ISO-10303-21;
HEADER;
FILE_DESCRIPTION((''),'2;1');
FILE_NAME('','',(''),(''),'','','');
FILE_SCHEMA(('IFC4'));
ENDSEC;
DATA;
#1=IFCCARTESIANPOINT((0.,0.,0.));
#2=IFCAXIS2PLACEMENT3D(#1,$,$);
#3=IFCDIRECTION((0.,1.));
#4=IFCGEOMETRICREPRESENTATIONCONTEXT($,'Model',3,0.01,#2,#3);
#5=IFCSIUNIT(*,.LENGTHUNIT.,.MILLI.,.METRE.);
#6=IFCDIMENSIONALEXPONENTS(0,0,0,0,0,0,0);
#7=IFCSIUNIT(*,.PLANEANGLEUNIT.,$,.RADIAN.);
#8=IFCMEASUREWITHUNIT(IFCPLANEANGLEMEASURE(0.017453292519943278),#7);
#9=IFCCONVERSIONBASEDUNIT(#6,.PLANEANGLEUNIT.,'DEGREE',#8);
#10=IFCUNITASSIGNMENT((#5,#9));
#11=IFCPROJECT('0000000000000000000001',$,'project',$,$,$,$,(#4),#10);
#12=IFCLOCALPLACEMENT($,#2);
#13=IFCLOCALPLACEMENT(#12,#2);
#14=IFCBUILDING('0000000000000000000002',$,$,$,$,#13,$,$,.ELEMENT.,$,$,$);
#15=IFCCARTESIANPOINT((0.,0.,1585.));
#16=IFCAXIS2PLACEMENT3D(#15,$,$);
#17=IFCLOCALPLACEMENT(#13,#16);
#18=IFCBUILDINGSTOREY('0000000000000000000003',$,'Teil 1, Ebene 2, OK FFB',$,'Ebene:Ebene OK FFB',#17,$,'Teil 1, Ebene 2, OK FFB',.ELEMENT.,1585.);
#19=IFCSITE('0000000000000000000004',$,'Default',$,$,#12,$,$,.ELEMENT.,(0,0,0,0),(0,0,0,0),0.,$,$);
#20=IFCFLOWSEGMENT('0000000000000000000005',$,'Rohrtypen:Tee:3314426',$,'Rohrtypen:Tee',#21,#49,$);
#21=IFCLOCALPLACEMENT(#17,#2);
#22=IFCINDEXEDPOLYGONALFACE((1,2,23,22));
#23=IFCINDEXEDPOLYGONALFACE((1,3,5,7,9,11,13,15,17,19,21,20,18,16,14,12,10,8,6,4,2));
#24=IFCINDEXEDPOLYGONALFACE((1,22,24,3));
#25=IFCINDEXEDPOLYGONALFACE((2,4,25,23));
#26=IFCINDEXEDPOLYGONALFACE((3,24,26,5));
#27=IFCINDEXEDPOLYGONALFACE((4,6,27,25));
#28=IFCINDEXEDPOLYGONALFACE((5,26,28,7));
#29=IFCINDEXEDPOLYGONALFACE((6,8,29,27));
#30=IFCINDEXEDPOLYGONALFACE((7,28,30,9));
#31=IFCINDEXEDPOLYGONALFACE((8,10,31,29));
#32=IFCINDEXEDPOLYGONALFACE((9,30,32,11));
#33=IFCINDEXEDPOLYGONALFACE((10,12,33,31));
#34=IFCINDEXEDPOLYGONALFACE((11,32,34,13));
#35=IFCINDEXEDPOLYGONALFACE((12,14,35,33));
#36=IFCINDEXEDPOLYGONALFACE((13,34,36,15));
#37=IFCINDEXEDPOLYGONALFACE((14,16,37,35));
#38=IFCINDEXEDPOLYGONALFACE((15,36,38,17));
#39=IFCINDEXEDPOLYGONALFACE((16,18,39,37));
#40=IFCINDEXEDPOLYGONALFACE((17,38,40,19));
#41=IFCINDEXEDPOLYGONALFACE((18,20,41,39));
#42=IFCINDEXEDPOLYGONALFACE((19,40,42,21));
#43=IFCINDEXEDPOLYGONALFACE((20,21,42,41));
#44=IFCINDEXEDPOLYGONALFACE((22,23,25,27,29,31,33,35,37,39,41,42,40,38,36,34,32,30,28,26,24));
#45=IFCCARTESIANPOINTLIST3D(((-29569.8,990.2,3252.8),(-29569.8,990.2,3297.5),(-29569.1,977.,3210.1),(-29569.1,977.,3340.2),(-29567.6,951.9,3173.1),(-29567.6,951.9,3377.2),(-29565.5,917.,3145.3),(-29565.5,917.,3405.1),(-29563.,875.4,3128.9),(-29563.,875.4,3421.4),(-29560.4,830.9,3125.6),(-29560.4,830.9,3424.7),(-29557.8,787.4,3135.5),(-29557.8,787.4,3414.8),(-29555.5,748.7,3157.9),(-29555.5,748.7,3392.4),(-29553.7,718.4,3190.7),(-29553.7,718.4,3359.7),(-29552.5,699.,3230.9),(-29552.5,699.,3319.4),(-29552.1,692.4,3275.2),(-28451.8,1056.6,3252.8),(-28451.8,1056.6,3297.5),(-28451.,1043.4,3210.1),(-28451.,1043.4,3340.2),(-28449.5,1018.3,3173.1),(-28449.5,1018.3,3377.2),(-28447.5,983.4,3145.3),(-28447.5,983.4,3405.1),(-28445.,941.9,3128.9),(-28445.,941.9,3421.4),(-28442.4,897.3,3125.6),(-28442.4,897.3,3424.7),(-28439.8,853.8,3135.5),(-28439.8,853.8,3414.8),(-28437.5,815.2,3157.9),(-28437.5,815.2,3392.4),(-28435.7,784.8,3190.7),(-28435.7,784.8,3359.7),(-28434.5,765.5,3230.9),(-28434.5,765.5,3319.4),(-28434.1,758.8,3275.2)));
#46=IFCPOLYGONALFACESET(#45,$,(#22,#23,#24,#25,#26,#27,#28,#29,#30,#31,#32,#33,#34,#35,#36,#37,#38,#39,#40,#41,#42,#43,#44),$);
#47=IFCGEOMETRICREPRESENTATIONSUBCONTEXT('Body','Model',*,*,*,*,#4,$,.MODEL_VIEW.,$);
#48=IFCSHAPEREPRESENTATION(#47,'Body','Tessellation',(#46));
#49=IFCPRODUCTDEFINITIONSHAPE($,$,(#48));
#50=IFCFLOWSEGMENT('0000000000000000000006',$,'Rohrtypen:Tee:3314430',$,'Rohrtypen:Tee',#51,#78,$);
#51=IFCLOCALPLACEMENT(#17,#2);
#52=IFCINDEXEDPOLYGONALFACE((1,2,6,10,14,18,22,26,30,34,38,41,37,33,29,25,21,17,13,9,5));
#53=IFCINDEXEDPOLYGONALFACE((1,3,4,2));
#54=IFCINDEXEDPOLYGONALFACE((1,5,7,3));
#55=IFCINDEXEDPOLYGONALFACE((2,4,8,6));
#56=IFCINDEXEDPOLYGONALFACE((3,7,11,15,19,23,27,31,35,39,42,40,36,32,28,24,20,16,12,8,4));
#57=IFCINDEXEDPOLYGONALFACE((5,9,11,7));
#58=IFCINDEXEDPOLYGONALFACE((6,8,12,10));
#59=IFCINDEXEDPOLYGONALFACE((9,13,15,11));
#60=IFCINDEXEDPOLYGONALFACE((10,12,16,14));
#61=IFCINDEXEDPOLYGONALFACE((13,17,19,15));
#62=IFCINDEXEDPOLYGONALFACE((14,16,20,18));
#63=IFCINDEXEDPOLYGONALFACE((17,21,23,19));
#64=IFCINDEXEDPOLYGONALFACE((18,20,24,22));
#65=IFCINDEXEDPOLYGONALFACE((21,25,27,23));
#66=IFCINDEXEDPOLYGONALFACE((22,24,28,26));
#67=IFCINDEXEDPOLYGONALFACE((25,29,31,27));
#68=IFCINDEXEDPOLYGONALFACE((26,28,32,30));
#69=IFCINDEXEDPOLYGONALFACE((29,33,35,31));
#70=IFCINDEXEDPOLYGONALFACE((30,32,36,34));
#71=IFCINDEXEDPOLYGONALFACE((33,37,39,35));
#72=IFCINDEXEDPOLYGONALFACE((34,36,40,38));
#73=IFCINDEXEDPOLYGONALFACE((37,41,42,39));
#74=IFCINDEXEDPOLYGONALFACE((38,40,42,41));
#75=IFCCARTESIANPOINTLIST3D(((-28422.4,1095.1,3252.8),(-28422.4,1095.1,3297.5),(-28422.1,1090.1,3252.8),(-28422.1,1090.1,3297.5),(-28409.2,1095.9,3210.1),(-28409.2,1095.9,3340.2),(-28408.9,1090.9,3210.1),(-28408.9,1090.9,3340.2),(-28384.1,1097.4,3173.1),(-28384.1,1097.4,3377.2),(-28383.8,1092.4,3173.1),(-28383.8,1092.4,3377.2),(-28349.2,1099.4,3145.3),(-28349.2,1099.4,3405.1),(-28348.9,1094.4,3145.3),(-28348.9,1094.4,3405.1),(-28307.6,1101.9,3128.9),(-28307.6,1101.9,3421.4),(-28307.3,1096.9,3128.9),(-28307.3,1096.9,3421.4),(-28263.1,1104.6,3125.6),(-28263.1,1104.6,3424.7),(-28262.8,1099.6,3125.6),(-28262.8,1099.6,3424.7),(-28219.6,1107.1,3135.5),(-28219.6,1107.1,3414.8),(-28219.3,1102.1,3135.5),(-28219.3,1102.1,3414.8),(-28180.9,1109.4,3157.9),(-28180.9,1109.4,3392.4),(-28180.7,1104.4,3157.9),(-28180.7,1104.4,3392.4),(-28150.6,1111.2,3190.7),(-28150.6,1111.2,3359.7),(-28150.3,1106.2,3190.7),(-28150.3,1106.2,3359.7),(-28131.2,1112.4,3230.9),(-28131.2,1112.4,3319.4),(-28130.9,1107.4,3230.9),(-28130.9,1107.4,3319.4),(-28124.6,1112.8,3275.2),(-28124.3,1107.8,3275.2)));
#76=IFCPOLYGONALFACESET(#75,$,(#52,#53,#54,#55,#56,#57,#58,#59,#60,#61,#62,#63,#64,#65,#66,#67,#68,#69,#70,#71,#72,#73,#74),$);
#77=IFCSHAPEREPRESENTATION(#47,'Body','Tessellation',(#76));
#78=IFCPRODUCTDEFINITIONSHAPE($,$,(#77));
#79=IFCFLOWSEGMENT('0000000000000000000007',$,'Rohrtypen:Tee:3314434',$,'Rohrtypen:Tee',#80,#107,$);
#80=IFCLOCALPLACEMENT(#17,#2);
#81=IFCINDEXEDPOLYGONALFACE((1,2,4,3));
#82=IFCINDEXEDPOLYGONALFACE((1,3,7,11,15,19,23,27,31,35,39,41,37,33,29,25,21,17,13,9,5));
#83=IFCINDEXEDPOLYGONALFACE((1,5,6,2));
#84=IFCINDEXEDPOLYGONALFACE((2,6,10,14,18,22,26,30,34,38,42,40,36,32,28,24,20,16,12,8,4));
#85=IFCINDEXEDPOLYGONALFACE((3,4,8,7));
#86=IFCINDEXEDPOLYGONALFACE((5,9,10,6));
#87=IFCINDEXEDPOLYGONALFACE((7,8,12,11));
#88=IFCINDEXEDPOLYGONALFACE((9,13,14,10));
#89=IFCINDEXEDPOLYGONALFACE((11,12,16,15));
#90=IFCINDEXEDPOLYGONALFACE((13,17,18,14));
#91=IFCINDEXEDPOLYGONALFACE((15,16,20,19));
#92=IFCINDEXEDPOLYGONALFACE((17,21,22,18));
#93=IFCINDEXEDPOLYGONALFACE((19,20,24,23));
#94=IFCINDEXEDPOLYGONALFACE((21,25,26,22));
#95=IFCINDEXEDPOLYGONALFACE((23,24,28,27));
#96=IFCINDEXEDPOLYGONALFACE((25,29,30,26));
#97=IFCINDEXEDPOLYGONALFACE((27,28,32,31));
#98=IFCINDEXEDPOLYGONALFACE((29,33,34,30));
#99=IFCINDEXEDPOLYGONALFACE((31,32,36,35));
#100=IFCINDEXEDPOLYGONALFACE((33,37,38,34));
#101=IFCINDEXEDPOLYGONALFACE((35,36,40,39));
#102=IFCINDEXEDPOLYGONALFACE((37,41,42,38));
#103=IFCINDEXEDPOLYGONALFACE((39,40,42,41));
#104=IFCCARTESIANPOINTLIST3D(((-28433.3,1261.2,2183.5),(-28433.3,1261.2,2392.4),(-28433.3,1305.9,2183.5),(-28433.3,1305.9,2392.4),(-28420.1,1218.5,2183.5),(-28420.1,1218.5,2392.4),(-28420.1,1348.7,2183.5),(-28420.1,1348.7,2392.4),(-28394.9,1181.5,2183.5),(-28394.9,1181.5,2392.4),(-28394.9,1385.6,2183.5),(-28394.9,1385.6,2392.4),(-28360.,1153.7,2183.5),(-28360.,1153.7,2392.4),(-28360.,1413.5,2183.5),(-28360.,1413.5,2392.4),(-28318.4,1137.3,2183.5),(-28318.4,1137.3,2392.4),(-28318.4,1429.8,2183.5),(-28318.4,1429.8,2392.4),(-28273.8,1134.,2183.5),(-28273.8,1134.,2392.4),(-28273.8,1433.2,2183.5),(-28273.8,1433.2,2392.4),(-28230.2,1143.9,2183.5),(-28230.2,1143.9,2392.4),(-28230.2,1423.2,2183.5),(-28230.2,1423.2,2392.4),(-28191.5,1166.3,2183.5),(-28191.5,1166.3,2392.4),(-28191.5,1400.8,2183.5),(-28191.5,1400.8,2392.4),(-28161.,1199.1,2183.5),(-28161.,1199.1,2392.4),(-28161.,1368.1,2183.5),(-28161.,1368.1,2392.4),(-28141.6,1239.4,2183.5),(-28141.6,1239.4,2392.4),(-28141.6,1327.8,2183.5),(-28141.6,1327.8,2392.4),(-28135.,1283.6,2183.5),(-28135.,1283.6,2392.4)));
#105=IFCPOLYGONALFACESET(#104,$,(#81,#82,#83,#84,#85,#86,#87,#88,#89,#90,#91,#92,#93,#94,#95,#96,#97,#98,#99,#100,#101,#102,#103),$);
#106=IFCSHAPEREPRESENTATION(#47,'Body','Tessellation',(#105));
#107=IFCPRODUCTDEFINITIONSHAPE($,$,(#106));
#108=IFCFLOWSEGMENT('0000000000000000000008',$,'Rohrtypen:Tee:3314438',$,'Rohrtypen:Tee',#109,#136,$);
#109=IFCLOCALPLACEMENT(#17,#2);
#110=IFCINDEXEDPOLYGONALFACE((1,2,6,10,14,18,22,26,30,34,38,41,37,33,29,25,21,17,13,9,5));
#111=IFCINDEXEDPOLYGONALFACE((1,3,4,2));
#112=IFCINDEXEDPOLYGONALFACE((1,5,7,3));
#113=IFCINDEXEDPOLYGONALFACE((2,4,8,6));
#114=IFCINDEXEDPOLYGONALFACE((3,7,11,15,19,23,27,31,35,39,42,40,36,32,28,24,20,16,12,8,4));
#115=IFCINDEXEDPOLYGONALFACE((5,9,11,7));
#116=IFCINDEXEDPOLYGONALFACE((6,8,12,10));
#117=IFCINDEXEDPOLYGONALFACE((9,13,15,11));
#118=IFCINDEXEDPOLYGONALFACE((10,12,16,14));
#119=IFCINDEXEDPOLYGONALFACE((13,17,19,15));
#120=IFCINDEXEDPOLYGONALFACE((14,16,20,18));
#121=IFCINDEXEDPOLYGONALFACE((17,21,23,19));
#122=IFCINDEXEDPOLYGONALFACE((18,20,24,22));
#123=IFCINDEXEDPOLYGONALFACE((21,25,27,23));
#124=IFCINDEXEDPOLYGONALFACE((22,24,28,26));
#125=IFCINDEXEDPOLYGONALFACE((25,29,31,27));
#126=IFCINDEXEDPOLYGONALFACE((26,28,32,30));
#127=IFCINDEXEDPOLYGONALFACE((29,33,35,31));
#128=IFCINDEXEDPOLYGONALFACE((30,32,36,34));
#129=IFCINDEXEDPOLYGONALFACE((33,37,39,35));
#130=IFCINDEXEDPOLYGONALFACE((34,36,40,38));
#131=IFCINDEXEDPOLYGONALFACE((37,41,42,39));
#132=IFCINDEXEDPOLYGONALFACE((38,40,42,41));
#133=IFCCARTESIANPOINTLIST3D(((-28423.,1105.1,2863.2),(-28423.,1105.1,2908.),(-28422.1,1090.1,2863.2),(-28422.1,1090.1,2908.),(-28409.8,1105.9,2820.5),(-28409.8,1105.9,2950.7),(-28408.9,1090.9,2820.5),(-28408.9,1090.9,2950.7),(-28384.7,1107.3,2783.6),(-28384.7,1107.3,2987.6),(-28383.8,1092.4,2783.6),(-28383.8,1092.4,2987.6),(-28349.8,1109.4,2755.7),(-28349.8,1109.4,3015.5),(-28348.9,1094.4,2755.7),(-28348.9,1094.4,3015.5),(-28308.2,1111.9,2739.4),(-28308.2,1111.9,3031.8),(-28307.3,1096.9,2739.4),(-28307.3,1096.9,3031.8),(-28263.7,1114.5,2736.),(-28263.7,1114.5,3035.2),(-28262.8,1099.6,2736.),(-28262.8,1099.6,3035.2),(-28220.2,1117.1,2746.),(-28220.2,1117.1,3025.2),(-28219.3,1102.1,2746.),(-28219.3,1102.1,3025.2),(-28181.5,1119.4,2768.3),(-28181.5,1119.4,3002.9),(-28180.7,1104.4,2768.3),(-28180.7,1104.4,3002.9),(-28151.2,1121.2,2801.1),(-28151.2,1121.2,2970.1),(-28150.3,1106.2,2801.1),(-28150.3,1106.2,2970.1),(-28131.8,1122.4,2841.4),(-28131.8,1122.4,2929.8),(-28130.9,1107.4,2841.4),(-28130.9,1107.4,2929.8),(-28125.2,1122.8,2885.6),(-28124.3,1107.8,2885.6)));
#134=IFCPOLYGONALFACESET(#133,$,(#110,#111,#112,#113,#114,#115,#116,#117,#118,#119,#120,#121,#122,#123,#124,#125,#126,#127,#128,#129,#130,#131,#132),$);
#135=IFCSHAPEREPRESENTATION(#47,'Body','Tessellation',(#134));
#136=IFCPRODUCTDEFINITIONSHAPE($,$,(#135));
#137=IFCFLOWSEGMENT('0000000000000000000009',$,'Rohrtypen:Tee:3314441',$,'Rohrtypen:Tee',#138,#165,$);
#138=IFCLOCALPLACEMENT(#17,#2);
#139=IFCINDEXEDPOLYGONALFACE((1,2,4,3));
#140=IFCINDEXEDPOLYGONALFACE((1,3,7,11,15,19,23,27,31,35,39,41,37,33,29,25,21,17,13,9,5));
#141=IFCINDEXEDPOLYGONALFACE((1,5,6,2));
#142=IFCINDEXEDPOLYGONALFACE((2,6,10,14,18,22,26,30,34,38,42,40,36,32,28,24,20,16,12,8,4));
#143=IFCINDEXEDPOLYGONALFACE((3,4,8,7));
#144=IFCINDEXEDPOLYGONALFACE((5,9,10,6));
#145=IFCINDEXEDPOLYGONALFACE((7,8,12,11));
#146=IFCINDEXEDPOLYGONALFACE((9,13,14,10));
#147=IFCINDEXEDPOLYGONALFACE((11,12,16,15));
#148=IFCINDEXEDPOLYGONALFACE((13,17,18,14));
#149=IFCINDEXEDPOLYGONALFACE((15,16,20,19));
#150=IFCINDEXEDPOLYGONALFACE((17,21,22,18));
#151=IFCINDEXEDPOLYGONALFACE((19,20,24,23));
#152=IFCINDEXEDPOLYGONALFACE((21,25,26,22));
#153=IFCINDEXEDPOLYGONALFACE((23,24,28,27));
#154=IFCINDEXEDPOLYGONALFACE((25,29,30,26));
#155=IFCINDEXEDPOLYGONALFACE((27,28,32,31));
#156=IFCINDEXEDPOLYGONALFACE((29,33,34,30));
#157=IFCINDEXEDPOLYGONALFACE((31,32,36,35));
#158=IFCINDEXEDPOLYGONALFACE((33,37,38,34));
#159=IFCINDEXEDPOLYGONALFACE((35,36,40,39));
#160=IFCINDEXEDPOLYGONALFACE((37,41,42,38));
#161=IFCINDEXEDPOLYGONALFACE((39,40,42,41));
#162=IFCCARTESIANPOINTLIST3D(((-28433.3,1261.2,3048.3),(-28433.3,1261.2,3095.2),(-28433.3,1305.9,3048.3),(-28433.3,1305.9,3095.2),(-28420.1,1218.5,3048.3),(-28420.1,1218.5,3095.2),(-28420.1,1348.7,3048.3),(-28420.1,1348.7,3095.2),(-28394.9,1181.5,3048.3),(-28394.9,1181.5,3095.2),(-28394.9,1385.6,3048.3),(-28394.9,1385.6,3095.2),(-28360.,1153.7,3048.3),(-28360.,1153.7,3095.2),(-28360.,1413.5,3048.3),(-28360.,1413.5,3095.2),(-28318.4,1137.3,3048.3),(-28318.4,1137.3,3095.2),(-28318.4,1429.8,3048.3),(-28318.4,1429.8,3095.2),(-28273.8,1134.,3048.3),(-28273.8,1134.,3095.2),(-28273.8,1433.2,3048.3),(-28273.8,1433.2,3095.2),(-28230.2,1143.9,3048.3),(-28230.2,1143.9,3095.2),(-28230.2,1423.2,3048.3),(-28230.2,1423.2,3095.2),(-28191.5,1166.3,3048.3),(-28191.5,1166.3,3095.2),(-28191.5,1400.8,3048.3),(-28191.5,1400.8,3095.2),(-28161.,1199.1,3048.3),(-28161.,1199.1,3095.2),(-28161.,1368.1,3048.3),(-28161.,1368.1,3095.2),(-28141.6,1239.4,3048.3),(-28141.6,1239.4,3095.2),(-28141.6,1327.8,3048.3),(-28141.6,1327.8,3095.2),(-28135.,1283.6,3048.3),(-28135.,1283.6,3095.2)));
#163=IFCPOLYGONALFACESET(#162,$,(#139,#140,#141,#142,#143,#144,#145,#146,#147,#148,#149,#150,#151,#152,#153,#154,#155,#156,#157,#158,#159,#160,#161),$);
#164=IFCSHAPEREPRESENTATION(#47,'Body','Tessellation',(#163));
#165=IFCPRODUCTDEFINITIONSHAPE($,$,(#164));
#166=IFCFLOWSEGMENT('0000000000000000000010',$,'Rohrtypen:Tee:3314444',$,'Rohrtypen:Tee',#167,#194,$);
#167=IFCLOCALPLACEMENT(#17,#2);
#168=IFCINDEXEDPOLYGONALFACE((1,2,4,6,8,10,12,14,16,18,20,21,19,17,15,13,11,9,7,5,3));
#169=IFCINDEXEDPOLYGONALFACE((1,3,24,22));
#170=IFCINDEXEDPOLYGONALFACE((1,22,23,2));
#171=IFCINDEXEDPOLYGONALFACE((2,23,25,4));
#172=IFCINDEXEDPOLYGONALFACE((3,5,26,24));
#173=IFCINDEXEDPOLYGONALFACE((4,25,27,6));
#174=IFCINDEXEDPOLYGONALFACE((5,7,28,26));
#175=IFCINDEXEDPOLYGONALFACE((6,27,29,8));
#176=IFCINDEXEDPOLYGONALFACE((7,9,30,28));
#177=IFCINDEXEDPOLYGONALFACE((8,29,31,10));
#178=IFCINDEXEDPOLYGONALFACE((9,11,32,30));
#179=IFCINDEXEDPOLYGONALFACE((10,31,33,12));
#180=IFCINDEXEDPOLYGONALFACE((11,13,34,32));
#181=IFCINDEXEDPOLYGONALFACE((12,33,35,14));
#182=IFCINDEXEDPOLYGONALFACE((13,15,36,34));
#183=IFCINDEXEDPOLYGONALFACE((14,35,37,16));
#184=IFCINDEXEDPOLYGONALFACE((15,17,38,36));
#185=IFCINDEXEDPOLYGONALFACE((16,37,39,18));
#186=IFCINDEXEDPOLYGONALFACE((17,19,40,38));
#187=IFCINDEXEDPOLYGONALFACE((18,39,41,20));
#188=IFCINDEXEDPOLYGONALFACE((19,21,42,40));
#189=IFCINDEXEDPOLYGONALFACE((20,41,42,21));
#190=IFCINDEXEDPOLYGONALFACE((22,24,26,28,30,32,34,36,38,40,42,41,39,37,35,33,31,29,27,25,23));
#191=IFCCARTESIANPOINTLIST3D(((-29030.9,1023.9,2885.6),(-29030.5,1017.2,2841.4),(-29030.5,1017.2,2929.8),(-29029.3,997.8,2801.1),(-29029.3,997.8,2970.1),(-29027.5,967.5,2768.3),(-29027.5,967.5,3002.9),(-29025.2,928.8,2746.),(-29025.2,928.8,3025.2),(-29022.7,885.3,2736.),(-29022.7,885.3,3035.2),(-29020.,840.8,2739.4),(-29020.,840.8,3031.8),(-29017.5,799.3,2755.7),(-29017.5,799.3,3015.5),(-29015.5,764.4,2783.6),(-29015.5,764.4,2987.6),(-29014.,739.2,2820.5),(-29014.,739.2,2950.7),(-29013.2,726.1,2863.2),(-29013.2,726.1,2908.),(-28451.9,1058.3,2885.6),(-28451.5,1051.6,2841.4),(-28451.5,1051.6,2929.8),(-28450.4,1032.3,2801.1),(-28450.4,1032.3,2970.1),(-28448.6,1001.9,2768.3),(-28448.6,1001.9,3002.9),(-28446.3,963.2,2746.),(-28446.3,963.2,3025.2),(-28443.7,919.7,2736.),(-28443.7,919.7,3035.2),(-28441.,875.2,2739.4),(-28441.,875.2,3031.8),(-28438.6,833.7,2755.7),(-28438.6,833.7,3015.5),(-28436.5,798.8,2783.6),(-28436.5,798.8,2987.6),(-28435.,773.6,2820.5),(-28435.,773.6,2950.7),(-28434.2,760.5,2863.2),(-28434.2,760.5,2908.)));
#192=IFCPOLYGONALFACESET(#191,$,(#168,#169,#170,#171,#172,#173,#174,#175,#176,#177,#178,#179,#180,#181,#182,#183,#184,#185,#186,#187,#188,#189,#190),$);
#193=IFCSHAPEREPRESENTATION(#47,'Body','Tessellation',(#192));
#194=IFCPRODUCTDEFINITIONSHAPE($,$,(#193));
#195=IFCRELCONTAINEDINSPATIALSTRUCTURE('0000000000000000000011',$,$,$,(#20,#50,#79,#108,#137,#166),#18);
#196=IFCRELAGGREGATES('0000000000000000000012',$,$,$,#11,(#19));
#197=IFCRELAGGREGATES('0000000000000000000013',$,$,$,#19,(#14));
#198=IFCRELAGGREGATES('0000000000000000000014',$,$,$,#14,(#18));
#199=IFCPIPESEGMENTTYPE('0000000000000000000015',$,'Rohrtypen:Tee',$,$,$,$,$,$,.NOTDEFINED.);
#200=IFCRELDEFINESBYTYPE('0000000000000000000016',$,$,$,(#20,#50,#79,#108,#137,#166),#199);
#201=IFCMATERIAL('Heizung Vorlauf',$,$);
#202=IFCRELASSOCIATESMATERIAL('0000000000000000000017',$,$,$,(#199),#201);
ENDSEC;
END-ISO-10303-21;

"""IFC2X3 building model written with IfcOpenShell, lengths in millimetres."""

from ifc_helpers import new_model, entity, si_unit, converted_unit, direction, frame, frame_2d, origin, origin_2d_with_axis, place, context, subcontext, project, spatial, circle, extrude, material, type_object, element, save


model = new_model("IFC2X3")

# Units and contexts
model_context = context("Model", 3, precision=0.01, world=origin(), true_north=direction((0.0, 1.0)))
body_context = subcontext(model_context, "Body", "Model", "MODEL_VIEW")
ifc_project = project(units=[si_unit("LENGTHUNIT", "METRE", prefix="MILLI"), converted_unit("PLANEANGLEUNIT", "DEGREE", entity("IfcPlaneAngleMeasure", 0.017453292519943278), si_unit("PLANEANGLEUNIT", "RADIAN"), dimensions=[0, 0, 0, 0, 0, 0, 0])], contexts=[model_context])

# Site, building, storey
site_placement = place(None, origin())
site = spatial("IfcSite", under=ifc_project, at=site_placement, Name="Default", CompositionType="ELEMENT", RefLatitude=(0, 0, 0, 0), RefLongitude=(0, 0, 0, 0), RefElevation=0.0)
building_placement = place(site_placement, origin())
building = spatial("IfcBuilding", under=site, at=building_placement, CompositionType="ELEMENT")
storey_placement = place(building_placement, frame((0.0, 0.0, 1585.0)))
storey = spatial("IfcBuildingStorey", under=building, at=storey_placement, Name="Teil 1, Ebene 2, OK FFB", ObjectType="Ebene:Ebene OK FFB", LongName="Teil 1, Ebene 2, OK FFB", CompositionType="ELEMENT", Elevation=1585.0)

# Flow segments
ifc_material = material(Name="Heizung Vorlauf")
pipe_segment_type = type_object("IfcPipeSegmentType", Name="Rohrtypen:Tee", PredefinedType="NOTDEFINED", material=ifc_material)
flow_segment_1_placement = place(storey_placement, origin())
element("IfcFlowSegment", 1, at=flow_segment_1_placement, inside=storey, type_object=pipe_segment_type, Name="Rohrtypen:Tee:3314426", ObjectType="Rohrtypen:Tee", context=body_context, shape_type="SweptSolid", body=[
    extrude(circle(Radius=150.0, at=frame_2d((0.0, 0.0), x_axis=(1.0, 0.0))), frame((-29561.0, 842.1, 3275.2), z_axis=(0.998239, 0.059319, 0.0), x_axis=(0.059319, -0.998239, 0.0)), (0.0, 0.0, 1.0), 1120.0),
])
flow_segment_2_placement = place(storey_placement, origin())
element("IfcFlowSegment", 2, at=flow_segment_2_placement, inside=storey, type_object=pipe_segment_type, Name="Rohrtypen:Tee:3314430", ObjectType="Rohrtypen:Tee", context=body_context, shape_type="SweptSolid", body=[
    extrude(circle(Radius=150.0, at=origin_2d_with_axis()), frame((-28274.3, 1103.9, 3275.2), z_axis=(0.059319, -0.998239, 0.0), x_axis=(0.998239, 0.059319, 0.0)), (0.0, 0.0, 1.0), 5.0),
])
flow_segment_3_placement = place(storey_placement, origin())
element("IfcFlowSegment", 3, at=flow_segment_3_placement, inside=storey, type_object=pipe_segment_type, Name="Rohrtypen:Tee:3314434", ObjectType="Rohrtypen:Tee", context=body_context, shape_type="SweptSolid", body=[
    extrude(circle(Radius=150.0, at=frame_2d((0.0, 0.0), x_axis=(1.0, 0.0))), frame((-28285.0, 1283.6, 2183.5)), (0.0, 0.0, 1.0), 208.9),
])
flow_segment_4_placement = place(storey_placement, origin())
element("IfcFlowSegment", 4, at=flow_segment_4_placement, inside=storey, type_object=pipe_segment_type, Name="Rohrtypen:Tee:3314438", ObjectType="Rohrtypen:Tee", context=body_context, shape_type="SweptSolid", body=[
    extrude(circle(Radius=150.0, at=origin_2d_with_axis()), frame((-28274.0, 1098.9, 2885.6), z_axis=(-0.059319, 0.998239, 0.0), x_axis=(0.998239, 0.059319, 0.0)), (0.0, 0.0, 1.0), 15.0),
])
flow_segment_5_placement = place(storey_placement, origin())
element("IfcFlowSegment", 5, at=flow_segment_5_placement, inside=storey, type_object=pipe_segment_type, Name="Rohrtypen:Tee:3314441", ObjectType="Rohrtypen:Tee", context=body_context, shape_type="SweptSolid", body=[
    extrude(circle(Radius=150.0, at=origin_2d_with_axis()), frame((-28285.0, 1283.6, 3048.3)), (0.0, 0.0, 1.0), 46.9),
])
flow_segment_6_placement = place(storey_placement, origin())
element("IfcFlowSegment", 6, at=flow_segment_6_placement, inside=storey, type_object=pipe_segment_type, Name="Rohrtypen:Tee:3314444", ObjectType="Rohrtypen:Tee", context=body_context, shape_type="SweptSolid", body=[
    extrude(circle(Radius=150.0, at=frame_2d((0.0, 0.0), x_axis=(1.0, 0.0))), frame((-29022.0, 874.1, 2885.6), z_axis=(0.998239, 0.059319, 0.0), x_axis=(-0.059319, 0.998239, 0.0)), (0.0, 0.0, 1.0), 580.0),
])

save(model, "model.ifc")
